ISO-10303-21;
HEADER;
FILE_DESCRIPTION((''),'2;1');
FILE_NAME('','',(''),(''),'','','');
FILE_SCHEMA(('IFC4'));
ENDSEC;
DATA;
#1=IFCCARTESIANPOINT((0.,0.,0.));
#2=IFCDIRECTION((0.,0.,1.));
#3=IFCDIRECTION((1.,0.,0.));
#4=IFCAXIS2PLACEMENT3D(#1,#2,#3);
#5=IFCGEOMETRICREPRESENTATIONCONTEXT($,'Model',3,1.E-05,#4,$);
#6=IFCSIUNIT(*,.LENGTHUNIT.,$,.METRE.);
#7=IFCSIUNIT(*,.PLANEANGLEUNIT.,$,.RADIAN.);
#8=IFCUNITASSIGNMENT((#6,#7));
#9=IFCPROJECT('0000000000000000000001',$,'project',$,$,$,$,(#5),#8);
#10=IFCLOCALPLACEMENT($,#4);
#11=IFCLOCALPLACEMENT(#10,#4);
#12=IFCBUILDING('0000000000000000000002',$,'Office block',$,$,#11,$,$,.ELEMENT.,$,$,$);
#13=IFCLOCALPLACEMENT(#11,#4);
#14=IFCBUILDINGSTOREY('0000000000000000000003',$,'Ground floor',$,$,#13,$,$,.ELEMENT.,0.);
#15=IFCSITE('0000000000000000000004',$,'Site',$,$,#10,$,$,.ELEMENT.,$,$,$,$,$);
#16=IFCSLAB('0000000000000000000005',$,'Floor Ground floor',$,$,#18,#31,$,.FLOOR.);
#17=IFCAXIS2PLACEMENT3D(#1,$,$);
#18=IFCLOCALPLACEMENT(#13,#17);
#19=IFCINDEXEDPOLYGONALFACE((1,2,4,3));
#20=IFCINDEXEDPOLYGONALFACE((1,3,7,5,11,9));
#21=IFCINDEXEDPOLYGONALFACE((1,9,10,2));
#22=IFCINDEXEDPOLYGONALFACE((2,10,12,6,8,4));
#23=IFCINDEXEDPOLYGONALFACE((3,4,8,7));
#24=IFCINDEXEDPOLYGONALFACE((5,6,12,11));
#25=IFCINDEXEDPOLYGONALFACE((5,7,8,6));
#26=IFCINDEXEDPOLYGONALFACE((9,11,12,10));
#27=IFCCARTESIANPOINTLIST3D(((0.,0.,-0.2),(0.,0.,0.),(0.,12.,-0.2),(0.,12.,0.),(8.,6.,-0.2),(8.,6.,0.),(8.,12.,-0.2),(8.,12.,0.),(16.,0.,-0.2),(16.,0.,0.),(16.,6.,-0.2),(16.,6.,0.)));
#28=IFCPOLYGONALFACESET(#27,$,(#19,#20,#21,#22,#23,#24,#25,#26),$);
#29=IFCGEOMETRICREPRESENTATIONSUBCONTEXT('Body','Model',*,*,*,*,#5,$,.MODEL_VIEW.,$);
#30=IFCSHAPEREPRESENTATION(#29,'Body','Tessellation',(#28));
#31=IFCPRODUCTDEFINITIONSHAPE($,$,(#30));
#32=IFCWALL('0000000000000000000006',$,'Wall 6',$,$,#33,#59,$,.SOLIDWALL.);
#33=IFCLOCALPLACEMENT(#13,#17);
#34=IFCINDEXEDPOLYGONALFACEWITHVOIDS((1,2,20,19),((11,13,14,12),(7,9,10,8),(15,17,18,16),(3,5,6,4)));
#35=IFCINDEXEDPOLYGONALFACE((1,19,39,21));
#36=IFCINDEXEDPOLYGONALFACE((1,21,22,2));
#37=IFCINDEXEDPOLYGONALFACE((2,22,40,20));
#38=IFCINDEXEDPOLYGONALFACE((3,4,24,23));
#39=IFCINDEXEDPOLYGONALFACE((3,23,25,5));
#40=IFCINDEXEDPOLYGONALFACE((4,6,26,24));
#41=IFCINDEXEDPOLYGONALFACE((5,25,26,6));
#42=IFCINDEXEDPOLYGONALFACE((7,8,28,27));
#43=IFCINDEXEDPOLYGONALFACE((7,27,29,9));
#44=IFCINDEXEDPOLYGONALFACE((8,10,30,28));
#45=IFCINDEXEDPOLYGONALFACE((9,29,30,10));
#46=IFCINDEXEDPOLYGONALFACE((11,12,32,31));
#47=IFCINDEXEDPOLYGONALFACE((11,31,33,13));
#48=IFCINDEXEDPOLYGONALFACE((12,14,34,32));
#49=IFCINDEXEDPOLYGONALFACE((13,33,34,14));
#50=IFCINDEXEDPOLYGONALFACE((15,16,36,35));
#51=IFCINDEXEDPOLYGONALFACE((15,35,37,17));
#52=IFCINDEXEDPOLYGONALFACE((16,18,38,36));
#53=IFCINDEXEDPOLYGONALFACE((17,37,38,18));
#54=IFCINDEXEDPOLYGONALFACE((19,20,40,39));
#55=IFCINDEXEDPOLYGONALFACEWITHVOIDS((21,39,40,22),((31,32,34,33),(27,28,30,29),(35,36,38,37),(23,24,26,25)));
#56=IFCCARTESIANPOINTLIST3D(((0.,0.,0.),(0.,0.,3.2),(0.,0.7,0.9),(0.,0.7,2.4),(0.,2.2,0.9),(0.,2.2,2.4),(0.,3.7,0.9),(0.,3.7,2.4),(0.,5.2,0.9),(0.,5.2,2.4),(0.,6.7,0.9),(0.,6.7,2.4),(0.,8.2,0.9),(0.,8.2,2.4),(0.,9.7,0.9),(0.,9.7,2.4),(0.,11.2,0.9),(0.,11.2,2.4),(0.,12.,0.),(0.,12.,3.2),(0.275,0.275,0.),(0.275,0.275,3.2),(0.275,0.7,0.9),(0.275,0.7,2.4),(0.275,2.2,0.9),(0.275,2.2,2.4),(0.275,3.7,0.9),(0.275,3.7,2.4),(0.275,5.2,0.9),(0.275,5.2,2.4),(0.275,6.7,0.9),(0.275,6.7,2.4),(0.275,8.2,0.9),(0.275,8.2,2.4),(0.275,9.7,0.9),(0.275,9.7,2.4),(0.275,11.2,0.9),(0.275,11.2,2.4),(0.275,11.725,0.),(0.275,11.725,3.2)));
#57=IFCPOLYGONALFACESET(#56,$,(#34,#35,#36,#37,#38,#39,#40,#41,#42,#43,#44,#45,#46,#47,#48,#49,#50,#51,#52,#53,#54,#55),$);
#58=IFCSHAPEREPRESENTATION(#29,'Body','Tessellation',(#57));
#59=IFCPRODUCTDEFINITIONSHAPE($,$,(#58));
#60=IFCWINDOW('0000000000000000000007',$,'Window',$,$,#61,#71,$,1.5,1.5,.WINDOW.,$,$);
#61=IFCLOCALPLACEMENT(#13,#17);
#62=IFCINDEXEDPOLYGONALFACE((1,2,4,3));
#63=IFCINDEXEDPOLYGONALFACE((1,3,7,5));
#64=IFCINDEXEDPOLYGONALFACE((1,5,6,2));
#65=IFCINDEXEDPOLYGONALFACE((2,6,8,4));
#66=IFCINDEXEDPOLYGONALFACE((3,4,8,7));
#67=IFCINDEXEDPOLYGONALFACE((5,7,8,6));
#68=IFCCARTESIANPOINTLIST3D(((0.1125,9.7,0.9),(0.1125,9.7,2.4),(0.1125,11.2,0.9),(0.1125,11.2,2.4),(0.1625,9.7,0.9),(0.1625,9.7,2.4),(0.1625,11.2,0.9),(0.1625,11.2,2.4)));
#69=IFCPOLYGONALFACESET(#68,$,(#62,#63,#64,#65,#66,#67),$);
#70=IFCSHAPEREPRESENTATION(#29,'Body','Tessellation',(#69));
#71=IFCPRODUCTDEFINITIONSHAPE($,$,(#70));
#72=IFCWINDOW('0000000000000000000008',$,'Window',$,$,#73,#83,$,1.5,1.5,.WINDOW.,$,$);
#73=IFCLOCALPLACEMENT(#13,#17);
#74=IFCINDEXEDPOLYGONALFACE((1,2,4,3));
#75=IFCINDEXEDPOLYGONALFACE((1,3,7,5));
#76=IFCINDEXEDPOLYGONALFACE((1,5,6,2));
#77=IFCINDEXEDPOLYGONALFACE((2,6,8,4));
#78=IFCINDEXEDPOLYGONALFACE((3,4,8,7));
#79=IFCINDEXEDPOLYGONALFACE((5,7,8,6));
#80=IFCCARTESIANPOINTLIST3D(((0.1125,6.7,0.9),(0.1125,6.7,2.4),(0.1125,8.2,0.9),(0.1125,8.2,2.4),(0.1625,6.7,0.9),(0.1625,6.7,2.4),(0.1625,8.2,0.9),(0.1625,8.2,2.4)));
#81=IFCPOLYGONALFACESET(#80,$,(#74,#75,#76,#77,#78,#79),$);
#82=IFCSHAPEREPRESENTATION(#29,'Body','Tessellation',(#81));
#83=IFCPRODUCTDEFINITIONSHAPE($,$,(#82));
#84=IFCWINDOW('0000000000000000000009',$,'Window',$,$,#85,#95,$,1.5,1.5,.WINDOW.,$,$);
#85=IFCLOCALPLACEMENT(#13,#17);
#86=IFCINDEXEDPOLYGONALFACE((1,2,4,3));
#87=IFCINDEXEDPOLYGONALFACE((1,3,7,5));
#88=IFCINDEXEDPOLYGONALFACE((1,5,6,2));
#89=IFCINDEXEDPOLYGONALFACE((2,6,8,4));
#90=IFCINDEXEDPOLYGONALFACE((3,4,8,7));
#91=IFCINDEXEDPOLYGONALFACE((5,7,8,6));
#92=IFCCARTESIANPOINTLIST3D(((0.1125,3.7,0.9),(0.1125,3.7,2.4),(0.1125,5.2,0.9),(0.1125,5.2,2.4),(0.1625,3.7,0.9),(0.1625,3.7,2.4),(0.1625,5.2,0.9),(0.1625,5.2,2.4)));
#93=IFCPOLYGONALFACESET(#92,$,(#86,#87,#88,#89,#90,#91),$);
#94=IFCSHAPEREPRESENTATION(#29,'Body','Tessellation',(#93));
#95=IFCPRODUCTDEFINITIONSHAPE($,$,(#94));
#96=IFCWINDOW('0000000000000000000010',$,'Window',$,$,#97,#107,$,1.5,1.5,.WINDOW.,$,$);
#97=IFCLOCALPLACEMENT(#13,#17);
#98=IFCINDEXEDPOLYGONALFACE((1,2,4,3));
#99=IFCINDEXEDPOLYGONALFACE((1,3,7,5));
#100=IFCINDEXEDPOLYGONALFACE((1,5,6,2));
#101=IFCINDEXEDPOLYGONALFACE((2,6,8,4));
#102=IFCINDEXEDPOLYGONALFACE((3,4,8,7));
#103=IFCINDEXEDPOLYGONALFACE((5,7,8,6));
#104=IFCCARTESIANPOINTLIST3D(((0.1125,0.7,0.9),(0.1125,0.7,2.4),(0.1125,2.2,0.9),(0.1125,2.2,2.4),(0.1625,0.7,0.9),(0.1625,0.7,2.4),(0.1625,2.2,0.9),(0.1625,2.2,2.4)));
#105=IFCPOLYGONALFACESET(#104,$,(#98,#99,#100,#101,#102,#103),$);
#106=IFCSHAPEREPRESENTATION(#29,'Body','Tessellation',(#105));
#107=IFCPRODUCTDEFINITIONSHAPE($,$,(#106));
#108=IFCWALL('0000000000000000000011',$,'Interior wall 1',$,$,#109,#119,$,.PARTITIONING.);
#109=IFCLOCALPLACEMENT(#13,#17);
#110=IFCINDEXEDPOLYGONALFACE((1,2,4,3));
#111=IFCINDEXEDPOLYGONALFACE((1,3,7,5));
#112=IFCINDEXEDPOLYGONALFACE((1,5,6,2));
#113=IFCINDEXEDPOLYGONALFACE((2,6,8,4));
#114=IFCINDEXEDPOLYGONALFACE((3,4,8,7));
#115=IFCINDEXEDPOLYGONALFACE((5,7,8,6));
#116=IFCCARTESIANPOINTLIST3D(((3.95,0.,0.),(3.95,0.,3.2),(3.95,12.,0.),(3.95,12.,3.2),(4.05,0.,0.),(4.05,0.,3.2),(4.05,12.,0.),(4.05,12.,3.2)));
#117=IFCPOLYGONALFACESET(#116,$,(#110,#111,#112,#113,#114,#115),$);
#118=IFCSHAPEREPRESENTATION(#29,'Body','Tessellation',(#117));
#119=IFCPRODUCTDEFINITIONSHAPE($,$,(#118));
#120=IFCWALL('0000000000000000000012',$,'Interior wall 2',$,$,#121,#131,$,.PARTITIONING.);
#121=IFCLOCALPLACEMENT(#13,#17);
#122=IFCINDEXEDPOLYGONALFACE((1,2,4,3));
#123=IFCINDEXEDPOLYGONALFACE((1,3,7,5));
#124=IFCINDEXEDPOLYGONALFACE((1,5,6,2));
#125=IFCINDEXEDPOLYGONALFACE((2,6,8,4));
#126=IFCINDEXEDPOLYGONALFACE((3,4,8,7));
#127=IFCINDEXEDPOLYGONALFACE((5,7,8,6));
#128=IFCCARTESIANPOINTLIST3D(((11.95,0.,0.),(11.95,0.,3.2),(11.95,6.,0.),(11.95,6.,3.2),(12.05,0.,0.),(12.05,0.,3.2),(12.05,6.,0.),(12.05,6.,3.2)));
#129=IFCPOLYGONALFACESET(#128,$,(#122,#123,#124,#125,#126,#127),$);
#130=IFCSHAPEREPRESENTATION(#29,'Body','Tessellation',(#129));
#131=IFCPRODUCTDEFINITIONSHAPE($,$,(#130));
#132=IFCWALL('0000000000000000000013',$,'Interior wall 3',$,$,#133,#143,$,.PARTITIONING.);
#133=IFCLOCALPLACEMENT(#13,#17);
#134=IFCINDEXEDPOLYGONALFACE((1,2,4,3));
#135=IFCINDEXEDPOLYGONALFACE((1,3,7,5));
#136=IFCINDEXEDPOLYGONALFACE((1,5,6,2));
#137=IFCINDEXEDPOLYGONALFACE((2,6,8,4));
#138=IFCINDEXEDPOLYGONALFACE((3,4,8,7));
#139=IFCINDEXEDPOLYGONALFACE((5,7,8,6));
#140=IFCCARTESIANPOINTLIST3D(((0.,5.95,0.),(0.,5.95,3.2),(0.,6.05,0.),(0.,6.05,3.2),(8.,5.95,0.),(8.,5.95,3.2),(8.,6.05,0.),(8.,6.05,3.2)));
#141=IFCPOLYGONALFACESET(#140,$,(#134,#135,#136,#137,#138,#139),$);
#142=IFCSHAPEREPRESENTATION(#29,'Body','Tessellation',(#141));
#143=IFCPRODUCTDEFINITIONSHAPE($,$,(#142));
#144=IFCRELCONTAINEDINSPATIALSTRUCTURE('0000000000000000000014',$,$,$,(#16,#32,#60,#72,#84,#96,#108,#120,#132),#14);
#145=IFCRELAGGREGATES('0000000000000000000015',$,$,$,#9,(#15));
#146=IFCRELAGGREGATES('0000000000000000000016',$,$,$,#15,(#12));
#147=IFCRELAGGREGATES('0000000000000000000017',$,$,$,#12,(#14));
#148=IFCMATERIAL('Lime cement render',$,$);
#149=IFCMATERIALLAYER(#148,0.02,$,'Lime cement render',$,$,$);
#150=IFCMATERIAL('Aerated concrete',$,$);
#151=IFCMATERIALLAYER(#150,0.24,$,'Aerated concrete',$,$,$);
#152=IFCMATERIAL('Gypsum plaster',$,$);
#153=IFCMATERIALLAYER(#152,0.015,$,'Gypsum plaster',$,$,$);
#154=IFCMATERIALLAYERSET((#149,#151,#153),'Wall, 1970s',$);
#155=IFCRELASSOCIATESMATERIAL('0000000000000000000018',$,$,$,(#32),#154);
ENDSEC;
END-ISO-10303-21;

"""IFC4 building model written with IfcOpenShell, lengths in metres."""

from ifc_helpers import new_model, si_unit, frame, origin_with_axes, place, context, subcontext, project, spatial, polyline, outline, extrude, material, layer, layer_set, layer_usage, element, fill, save


model = new_model("IFC4")

# Units and contexts
model_context = context("Model", 3, precision=1e-05, world=origin_with_axes())
body_context = subcontext(model_context, "Body", "Model", "MODEL_VIEW")
ifc_project = project(units=[si_unit("LENGTHUNIT", "METRE"), si_unit("PLANEANGLEUNIT", "RADIAN")], contexts=[model_context])

# Site, building, storey
site_placement = place(None, origin_with_axes())
site = spatial("IfcSite", under=ifc_project, at=site_placement, Name="Site", CompositionType="ELEMENT")
building_placement = place(site_placement, origin_with_axes())
building = spatial("IfcBuilding", under=site, at=building_placement, Name="Office block", CompositionType="ELEMENT")
storey_placement = place(building_placement, origin_with_axes())
storey = spatial("IfcBuildingStorey", under=building, at=storey_placement, Name="Ground floor", CompositionType="ELEMENT", Elevation=0.0)

# Slab
slab_placement = place(storey_placement, origin_with_axes())
element("IfcSlab", 1, at=slab_placement, inside=storey, Name="Floor Ground floor", PredefinedType="FLOOR", context=body_context, shape_type="SweptSolid", body=[
    extrude(outline(polyline([(0.0, 0.0), (16.0, 0.0), (16.0, 6.0), (8.0, 6.0), (8.0, 12.0), (0.0, 12.0), (0.0, 0.0)])), frame((0.0, 0.0, -0.2), z_axis=(0.0, 0.0, 1.0), x_axis=(1.0, 0.0, 0.0)), (0.0, 0.0, 1.0), 0.2),
])

# Wall, openings, windows
ifc_material_1 = material(Name="Lime cement render")
ifc_layer_1 = layer(ifc_material_1, 0.02, Name="Lime cement render")
ifc_material_2 = material(Name="Aerated concrete")
ifc_layer_2 = layer(ifc_material_2, 0.24, Name="Aerated concrete")
ifc_material_3 = material(Name="Gypsum plaster")
ifc_layer_3 = layer(ifc_material_3, 0.015, Name="Gypsum plaster")
ifc_layer_set = layer_set([ifc_layer_1, ifc_layer_2, ifc_layer_3], Name="Wall, 1970s")
ifc_layer_usage = layer_usage(ifc_layer_set, "AXIS2", "NEGATIVE", 0.0)
wall_1_placement = place(storey_placement, origin_with_axes())
wall_1 = element("IfcWall", 2, at=wall_1_placement, inside=storey, material=ifc_layer_usage, Name="Wall 6", PredefinedType="SOLIDWALL", context=body_context, shape_type="SweptSolid", body=[
    extrude(outline(polyline([(0.0, 12.0), (0.0, 0.0), (0.275, 0.275), (0.275, 11.725), (0.0, 12.0)])), origin_with_axes(), (0.0, 0.0, 1.0), 3.2),
])
opening_1_placement = place(storey_placement, origin_with_axes())
opening_1 = element("IfcOpeningElement", 3, at=opening_1_placement, cuts=wall_1, PredefinedType="OPENING", context=body_context, shape_type="SweptSolid", body=[
    extrude(outline(polyline([(-0.01, 11.2), (-0.01, 9.7), (0.285, 9.7), (0.285, 11.2), (-0.01, 11.2)])), frame((0.0, 0.0, 0.9), z_axis=(0.0, 0.0, 1.0), x_axis=(1.0, 0.0, 0.0)), (0.0, 0.0, 1.0), 1.5),
])
opening_2_placement = place(storey_placement, origin_with_axes())
opening_2 = element("IfcOpeningElement", 4, at=opening_2_placement, cuts=wall_1, PredefinedType="OPENING", context=body_context, shape_type="SweptSolid", body=[
    extrude(outline(polyline([(-0.01, 8.2), (-0.01, 6.7), (0.285, 6.7), (0.285, 8.2), (-0.01, 8.2)])), frame((0.0, 0.0, 0.9), z_axis=(0.0, 0.0, 1.0), x_axis=(1.0, 0.0, 0.0)), (0.0, 0.0, 1.0), 1.5),
])
opening_3_placement = place(storey_placement, origin_with_axes())
opening_3 = element("IfcOpeningElement", 5, at=opening_3_placement, cuts=wall_1, PredefinedType="OPENING", context=body_context, shape_type="SweptSolid", body=[
    extrude(outline(polyline([(-0.01, 5.2), (-0.01, 3.7), (0.285, 3.7), (0.285, 5.2), (-0.01, 5.2)])), frame((0.0, 0.0, 0.9), z_axis=(0.0, 0.0, 1.0), x_axis=(1.0, 0.0, 0.0)), (0.0, 0.0, 1.0), 1.5),
])
opening_4_placement = place(storey_placement, origin_with_axes())
opening_4 = element("IfcOpeningElement", 6, at=opening_4_placement, cuts=wall_1, PredefinedType="OPENING", context=body_context, shape_type="SweptSolid", body=[
    extrude(outline(polyline([(-0.01, 2.2), (-0.01, 0.7), (0.285, 0.7), (0.285, 2.2), (-0.01, 2.2)])), frame((0.0, 0.0, 0.9), z_axis=(0.0, 0.0, 1.0), x_axis=(1.0, 0.0, 0.0)), (0.0, 0.0, 1.0), 1.5),
])
window_1_placement = place(storey_placement, origin_with_axes())
window_1 = element("IfcWindow", 7, at=window_1_placement, inside=storey, Name="Window", OverallHeight=1.5, OverallWidth=1.5, PredefinedType="WINDOW", context=body_context, shape_type="SweptSolid", body=[
    extrude(outline(polyline([(0.1125, 11.2), (0.1125, 9.7), (0.1625, 9.7), (0.1625, 11.2), (0.1125, 11.2)])), frame((0.0, 0.0, 0.9), z_axis=(0.0, 0.0, 1.0), x_axis=(1.0, 0.0, 0.0)), (0.0, 0.0, 1.0), 1.5),
])
fill(opening_1, window_1)
window_2_placement = place(storey_placement, origin_with_axes())
window_2 = element("IfcWindow", 8, at=window_2_placement, inside=storey, Name="Window", OverallHeight=1.5, OverallWidth=1.5, PredefinedType="WINDOW", context=body_context, shape_type="SweptSolid", body=[
    extrude(outline(polyline([(0.1125, 8.2), (0.1125, 6.7), (0.1625, 6.7), (0.1625, 8.2), (0.1125, 8.2)])), frame((0.0, 0.0, 0.9), z_axis=(0.0, 0.0, 1.0), x_axis=(1.0, 0.0, 0.0)), (0.0, 0.0, 1.0), 1.5),
])
fill(opening_2, window_2)
window_3_placement = place(storey_placement, origin_with_axes())
window_3 = element("IfcWindow", 9, at=window_3_placement, inside=storey, Name="Window", OverallHeight=1.5, OverallWidth=1.5, PredefinedType="WINDOW", context=body_context, shape_type="SweptSolid", body=[
    extrude(outline(polyline([(0.1125, 5.2), (0.1125, 3.7), (0.1625, 3.7), (0.1625, 5.2), (0.1125, 5.2)])), frame((0.0, 0.0, 0.9), z_axis=(0.0, 0.0, 1.0), x_axis=(1.0, 0.0, 0.0)), (0.0, 0.0, 1.0), 1.5),
])
fill(opening_3, window_3)
window_4_placement = place(storey_placement, origin_with_axes())
window_4 = element("IfcWindow", 10, at=window_4_placement, inside=storey, Name="Window", OverallHeight=1.5, OverallWidth=1.5, PredefinedType="WINDOW", context=body_context, shape_type="SweptSolid", body=[
    extrude(outline(polyline([(0.1125, 2.2), (0.1125, 0.7), (0.1625, 0.7), (0.1625, 2.2), (0.1125, 2.2)])), frame((0.0, 0.0, 0.9), z_axis=(0.0, 0.0, 1.0), x_axis=(1.0, 0.0, 0.0)), (0.0, 0.0, 1.0), 1.5),
])
fill(opening_4, window_4)

# Walls
wall_2_placement = place(storey_placement, origin_with_axes())
element("IfcWall", 11, at=wall_2_placement, inside=storey, Name="Interior wall 1", PredefinedType="PARTITIONING", context=body_context, shape_type="SweptSolid", body=[
    extrude(outline(polyline([(3.95, 0.0), (3.95, 12.0), (4.05, 12.0), (4.05, 0.0), (3.95, 0.0)])), origin_with_axes(), (0.0, 0.0, 1.0), 3.2),
])
wall_3_placement = place(storey_placement, origin_with_axes())
element("IfcWall", 12, at=wall_3_placement, inside=storey, Name="Interior wall 2", PredefinedType="PARTITIONING", context=body_context, shape_type="SweptSolid", body=[
    extrude(outline(polyline([(11.95, 0.0), (11.95, 6.0), (12.05, 6.0), (12.05, 0.0), (11.95, 0.0)])), origin_with_axes(), (0.0, 0.0, 1.0), 3.2),
])
wall_4_placement = place(storey_placement, origin_with_axes())
element("IfcWall", 13, at=wall_4_placement, inside=storey, Name="Interior wall 3", PredefinedType="PARTITIONING", context=body_context, shape_type="SweptSolid", body=[
    extrude(outline(polyline([(0.0, 6.05), (8.0, 6.05), (8.0, 5.95), (0.0, 5.95), (0.0, 6.05)])), origin_with_axes(), (0.0, 0.0, 1.0), 3.2),
])

save(model, "model.ifc")
